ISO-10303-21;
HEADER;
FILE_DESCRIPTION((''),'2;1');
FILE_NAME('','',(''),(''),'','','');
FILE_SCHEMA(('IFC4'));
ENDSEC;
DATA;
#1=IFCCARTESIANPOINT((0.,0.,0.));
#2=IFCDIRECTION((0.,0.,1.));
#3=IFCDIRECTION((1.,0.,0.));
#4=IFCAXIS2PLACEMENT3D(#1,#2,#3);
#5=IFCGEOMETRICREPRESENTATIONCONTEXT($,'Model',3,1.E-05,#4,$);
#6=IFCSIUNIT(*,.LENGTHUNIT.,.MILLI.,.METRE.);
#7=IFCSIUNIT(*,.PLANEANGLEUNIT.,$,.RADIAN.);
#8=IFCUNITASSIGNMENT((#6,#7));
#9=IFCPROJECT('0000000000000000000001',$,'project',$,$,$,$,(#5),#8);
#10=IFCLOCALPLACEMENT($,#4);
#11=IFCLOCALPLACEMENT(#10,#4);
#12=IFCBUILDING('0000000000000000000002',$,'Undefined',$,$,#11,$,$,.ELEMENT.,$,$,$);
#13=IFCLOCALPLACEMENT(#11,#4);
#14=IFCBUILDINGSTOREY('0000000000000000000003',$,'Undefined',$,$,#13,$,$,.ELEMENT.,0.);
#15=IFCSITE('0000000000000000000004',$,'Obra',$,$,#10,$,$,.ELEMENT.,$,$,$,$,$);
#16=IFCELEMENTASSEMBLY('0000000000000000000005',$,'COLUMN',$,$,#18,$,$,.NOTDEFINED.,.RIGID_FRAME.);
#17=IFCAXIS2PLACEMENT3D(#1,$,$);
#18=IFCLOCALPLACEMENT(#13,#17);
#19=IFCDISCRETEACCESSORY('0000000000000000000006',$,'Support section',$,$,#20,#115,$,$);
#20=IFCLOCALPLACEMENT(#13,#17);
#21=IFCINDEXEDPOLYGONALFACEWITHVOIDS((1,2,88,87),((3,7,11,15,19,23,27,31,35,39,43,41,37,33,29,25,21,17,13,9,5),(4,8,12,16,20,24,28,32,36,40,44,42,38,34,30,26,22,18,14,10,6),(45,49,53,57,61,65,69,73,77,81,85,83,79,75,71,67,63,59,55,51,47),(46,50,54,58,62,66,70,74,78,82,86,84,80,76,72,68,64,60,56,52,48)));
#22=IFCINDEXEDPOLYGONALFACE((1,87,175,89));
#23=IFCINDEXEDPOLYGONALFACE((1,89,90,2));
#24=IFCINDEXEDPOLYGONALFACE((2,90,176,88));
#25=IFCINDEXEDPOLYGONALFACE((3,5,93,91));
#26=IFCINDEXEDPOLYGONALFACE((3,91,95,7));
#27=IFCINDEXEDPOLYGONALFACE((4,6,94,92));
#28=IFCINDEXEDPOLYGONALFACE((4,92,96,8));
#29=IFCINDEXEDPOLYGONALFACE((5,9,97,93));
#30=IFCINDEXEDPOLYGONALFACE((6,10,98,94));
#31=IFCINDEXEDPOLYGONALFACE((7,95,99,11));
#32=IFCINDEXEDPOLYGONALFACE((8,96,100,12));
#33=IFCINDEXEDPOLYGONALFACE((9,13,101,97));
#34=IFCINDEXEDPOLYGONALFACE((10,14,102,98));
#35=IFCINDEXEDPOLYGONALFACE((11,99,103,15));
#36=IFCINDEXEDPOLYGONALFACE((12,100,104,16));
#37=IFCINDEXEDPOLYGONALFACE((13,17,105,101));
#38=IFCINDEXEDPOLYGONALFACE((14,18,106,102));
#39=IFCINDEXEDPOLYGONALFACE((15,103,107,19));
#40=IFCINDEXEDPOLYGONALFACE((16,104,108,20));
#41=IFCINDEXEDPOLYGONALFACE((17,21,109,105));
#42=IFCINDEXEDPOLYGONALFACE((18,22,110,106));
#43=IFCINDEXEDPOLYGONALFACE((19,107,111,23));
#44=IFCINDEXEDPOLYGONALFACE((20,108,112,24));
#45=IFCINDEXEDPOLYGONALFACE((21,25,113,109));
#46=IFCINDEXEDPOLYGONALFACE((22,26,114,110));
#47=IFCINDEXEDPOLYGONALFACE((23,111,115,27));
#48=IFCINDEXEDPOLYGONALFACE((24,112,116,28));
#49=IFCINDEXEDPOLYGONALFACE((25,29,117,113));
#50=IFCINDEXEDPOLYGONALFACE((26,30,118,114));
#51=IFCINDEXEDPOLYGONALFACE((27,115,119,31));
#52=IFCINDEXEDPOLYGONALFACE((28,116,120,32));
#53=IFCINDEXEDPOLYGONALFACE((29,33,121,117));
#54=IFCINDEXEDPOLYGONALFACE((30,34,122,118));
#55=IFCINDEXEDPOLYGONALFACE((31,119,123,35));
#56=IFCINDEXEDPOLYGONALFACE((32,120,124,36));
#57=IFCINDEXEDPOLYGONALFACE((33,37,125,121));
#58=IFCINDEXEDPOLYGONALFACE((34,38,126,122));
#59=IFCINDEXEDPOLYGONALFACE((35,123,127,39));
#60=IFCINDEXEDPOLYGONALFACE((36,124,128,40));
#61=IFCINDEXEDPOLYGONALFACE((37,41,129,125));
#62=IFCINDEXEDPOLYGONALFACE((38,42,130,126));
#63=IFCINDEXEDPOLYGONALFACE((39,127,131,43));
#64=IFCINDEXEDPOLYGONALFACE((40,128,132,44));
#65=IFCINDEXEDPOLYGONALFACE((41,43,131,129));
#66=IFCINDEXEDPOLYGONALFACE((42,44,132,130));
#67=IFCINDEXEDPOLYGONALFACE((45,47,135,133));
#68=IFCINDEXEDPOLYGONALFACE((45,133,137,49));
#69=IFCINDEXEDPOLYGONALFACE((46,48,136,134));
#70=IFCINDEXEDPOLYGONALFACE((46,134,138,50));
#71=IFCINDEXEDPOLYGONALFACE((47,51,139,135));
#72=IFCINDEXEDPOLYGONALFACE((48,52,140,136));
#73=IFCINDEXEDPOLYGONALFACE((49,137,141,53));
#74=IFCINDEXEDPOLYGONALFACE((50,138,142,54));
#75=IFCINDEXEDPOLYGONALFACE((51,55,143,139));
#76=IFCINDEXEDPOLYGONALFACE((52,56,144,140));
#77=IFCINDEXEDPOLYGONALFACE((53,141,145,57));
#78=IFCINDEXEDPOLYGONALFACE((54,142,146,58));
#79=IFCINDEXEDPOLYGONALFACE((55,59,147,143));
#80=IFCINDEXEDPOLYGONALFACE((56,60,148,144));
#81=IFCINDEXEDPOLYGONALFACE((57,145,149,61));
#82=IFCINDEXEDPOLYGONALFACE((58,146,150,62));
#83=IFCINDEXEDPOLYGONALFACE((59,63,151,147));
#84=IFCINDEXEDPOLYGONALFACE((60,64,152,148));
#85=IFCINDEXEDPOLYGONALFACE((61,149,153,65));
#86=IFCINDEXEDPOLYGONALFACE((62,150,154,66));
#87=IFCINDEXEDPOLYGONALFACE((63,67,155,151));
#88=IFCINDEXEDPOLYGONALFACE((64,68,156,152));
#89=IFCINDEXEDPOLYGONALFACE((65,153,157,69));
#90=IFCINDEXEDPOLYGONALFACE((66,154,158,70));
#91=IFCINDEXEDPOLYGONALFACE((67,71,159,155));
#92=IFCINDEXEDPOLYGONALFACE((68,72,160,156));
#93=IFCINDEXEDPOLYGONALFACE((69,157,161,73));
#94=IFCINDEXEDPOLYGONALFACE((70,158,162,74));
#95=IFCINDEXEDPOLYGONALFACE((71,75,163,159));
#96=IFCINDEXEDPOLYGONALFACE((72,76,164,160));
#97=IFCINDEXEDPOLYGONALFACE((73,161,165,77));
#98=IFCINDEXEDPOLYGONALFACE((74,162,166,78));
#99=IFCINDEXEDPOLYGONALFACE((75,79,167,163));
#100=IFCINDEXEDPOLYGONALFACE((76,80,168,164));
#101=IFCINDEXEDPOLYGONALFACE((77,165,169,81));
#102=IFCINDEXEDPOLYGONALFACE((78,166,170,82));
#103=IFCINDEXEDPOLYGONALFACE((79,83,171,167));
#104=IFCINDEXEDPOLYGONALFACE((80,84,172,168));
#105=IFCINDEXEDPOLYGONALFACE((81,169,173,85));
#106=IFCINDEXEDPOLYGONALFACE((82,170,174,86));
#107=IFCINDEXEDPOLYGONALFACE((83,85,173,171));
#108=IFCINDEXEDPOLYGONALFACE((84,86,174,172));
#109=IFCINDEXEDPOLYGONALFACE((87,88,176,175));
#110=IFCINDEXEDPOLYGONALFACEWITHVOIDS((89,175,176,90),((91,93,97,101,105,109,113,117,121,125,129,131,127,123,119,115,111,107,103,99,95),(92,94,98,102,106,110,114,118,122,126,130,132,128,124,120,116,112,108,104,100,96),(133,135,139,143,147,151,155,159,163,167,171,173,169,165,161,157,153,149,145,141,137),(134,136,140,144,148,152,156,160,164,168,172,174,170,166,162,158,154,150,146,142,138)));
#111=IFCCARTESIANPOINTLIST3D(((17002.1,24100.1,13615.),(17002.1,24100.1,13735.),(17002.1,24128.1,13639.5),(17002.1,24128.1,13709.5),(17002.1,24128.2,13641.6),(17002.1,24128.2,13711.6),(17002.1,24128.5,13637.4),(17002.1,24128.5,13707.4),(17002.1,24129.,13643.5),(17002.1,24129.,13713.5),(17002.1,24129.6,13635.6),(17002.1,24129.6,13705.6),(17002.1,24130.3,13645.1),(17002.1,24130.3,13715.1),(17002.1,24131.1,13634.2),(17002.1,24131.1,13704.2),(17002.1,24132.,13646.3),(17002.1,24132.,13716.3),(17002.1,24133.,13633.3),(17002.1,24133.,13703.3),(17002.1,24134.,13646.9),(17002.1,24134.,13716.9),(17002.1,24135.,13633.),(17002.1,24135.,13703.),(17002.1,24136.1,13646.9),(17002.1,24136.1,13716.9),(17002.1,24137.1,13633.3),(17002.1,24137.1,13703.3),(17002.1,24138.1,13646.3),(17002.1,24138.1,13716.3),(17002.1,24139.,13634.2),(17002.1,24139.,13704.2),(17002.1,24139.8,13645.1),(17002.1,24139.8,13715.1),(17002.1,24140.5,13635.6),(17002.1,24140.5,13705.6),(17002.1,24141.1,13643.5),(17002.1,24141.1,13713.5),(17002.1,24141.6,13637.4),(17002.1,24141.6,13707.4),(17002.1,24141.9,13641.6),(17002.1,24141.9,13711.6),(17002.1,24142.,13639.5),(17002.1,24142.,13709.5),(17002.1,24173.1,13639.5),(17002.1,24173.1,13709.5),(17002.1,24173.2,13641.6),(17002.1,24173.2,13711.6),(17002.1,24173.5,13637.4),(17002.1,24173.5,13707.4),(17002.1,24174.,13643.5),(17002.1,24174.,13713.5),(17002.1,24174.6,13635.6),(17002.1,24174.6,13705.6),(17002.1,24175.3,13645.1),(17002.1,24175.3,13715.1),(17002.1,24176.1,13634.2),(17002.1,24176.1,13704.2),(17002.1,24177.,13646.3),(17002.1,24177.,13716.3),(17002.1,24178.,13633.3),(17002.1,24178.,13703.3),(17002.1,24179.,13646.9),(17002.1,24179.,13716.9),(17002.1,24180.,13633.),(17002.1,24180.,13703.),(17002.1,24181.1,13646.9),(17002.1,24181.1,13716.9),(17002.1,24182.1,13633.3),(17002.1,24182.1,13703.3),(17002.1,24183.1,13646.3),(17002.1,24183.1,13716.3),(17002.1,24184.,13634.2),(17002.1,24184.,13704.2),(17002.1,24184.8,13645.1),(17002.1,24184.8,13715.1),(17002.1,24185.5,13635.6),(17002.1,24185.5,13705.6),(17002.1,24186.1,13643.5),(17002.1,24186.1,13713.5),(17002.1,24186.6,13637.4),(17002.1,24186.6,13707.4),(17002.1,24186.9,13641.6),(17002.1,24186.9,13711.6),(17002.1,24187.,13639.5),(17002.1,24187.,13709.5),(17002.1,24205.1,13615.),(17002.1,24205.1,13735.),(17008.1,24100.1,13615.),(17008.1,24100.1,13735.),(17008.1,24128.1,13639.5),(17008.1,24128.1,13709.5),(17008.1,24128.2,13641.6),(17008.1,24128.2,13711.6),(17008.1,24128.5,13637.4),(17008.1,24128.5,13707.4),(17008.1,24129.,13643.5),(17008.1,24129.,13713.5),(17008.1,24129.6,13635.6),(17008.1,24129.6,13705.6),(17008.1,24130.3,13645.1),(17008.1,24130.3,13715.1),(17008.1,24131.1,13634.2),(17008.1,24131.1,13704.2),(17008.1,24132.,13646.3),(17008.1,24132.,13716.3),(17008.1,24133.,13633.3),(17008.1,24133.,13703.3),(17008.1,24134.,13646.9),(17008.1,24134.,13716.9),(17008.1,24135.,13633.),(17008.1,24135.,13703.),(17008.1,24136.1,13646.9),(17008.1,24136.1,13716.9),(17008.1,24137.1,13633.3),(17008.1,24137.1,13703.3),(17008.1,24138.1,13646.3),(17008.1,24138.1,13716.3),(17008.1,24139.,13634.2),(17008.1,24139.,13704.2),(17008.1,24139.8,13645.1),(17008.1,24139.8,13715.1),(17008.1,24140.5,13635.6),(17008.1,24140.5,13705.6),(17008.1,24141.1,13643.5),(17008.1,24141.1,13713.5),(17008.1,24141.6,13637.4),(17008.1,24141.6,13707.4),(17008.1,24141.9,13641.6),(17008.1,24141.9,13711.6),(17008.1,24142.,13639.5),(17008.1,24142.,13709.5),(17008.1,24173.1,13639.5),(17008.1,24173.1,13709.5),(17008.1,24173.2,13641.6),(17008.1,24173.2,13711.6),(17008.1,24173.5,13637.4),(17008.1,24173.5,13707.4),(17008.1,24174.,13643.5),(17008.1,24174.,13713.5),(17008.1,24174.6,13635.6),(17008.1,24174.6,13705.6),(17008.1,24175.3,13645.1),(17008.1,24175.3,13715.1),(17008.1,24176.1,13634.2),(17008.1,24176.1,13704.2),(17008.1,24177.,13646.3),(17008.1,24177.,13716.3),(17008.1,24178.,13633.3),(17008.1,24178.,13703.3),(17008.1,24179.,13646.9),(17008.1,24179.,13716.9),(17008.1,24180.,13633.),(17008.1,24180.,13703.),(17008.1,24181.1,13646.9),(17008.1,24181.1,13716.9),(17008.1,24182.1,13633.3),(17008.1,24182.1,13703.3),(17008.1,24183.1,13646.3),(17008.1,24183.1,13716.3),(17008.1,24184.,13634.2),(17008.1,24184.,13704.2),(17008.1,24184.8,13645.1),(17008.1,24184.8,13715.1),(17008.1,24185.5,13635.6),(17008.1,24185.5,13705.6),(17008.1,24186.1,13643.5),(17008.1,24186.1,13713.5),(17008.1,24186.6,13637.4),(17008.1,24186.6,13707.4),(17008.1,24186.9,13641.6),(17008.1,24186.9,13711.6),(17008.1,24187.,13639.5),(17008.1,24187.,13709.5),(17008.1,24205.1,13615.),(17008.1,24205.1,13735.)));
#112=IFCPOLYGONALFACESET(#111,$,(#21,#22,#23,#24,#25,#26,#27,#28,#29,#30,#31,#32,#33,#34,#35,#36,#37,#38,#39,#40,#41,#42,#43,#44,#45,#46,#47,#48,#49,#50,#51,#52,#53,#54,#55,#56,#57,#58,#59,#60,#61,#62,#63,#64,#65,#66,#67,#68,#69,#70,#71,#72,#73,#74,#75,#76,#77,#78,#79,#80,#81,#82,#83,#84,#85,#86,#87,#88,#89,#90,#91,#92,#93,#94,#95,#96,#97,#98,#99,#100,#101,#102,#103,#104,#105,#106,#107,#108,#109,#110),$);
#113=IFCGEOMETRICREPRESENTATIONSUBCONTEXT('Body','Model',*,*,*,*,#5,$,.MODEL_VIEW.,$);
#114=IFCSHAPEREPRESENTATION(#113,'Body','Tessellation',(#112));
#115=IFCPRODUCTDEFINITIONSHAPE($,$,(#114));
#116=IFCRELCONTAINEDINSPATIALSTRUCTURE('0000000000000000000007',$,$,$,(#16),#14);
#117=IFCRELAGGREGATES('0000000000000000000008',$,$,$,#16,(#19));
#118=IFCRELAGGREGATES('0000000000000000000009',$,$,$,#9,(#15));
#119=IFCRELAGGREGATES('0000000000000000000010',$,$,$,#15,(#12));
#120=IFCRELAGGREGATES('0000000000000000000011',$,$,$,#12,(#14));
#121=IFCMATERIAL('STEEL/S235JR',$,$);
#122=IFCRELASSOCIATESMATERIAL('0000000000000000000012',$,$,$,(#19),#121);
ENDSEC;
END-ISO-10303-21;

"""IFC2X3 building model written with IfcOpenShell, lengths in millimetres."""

from ifc_helpers import new_model, si_unit, frame, origin_with_axes, origin_2d_with_axis, place, context, subcontext, project, spatial, rectangle, circle, extrude, source, transform, mapped, material, element, aggregate, save


model = new_model("IFC2X3")

# Units and contexts
model_context = context("Model", 3, precision=1e-05, world=origin_with_axes())
body_context = subcontext(model_context, "Body", "Model", "MODEL_VIEW")
ifc_project = project(units=[si_unit("LENGTHUNIT", "METRE", prefix="MILLI"), si_unit("PLANEANGLEUNIT", "RADIAN")], contexts=[model_context])

# Site, building, storey
site_placement = place(None, origin_with_axes())
site = spatial("IfcSite", under=ifc_project, at=site_placement, Name="Obra", CompositionType="ELEMENT")
building_placement = place(site_placement, origin_with_axes())
building = spatial("IfcBuilding", under=site, at=building_placement, Name="Undefined", CompositionType="ELEMENT")
storey_placement = place(building_placement, origin_with_axes())
storey = spatial("IfcBuildingStorey", under=building, at=storey_placement, Name="Undefined", CompositionType="ELEMENT", Elevation=0.0)

# Element assembly
ifc_material_1 = material(Name="STEEL/S235JR")
assembly_1_placement = place(storey_placement, origin_with_axes())
assembly_1 = element("IfcElementAssembly", 1, at=assembly_1_placement, inside=storey, Name="COLUMN", AssemblyPlace="NOTDEFINED", PredefinedType="RIGID_FRAME")

# Discrete accessory, opening
shared_shape_1 = source(origin_with_axes(), body_context, "Body", "SweptSolid", [
    extrude(circle(Radius=7.0, at=origin_2d_with_axis()), frame((0.0, -8.6, 0.0), z_axis=(0.0, 1.0, 0.0), x_axis=(1.0, 0.0, 0.0)), (0.0, 0.0, 1.0), 6.2),
])
discrete_accessory_1_placement = place(assembly_1_placement, frame((17005.1, 24152.6, 13615.0), z_axis=(0.0, 0.0, 1.0), x_axis=(0.0, -1.0, 0.0)))
discrete_accessory_1 = element("IfcDiscreteAccessory", 2, at=discrete_accessory_1_placement, material=ifc_material_1, Name="Support section", context=body_context, shape_type="SweptSolid", body=[
    extrude(rectangle(XDim=6.0, YDim=105.0, at=origin_2d_with_axis()), frame((0.0, 0.0, 120.0), z_axis=(0.0, 0.0, -1.0), x_axis=(0.0, 1.0, 0.0)), (0.0, 0.0, 1.0), 120.0),
])
opening_1_placement = place(assembly_1_placement, frame((16999.6, 24110.0, 13755.0), z_axis=(0.0, 1.0, 0.0), x_axis=(0.0, 0.0, -1.0)))
element("IfcOpeningElement", 3, at=opening_1_placement, cuts=discrete_accessory_1, ObjectType="Opening", context=body_context, shape_type="MappedRepresentation", body=[
    mapped(shared_shape_1, transform((45.0, 0.0, 25.0))),
    mapped(shared_shape_1, transform((45.0, 0.0, 70.0))),
    mapped(shared_shape_1, transform((115.0, 0.0, 25.0))),
    mapped(shared_shape_1, transform((115.0, 0.0, 70.0))),
])
aggregate(assembly_1, [discrete_accessory_1])

save(model, "model.ifc")
